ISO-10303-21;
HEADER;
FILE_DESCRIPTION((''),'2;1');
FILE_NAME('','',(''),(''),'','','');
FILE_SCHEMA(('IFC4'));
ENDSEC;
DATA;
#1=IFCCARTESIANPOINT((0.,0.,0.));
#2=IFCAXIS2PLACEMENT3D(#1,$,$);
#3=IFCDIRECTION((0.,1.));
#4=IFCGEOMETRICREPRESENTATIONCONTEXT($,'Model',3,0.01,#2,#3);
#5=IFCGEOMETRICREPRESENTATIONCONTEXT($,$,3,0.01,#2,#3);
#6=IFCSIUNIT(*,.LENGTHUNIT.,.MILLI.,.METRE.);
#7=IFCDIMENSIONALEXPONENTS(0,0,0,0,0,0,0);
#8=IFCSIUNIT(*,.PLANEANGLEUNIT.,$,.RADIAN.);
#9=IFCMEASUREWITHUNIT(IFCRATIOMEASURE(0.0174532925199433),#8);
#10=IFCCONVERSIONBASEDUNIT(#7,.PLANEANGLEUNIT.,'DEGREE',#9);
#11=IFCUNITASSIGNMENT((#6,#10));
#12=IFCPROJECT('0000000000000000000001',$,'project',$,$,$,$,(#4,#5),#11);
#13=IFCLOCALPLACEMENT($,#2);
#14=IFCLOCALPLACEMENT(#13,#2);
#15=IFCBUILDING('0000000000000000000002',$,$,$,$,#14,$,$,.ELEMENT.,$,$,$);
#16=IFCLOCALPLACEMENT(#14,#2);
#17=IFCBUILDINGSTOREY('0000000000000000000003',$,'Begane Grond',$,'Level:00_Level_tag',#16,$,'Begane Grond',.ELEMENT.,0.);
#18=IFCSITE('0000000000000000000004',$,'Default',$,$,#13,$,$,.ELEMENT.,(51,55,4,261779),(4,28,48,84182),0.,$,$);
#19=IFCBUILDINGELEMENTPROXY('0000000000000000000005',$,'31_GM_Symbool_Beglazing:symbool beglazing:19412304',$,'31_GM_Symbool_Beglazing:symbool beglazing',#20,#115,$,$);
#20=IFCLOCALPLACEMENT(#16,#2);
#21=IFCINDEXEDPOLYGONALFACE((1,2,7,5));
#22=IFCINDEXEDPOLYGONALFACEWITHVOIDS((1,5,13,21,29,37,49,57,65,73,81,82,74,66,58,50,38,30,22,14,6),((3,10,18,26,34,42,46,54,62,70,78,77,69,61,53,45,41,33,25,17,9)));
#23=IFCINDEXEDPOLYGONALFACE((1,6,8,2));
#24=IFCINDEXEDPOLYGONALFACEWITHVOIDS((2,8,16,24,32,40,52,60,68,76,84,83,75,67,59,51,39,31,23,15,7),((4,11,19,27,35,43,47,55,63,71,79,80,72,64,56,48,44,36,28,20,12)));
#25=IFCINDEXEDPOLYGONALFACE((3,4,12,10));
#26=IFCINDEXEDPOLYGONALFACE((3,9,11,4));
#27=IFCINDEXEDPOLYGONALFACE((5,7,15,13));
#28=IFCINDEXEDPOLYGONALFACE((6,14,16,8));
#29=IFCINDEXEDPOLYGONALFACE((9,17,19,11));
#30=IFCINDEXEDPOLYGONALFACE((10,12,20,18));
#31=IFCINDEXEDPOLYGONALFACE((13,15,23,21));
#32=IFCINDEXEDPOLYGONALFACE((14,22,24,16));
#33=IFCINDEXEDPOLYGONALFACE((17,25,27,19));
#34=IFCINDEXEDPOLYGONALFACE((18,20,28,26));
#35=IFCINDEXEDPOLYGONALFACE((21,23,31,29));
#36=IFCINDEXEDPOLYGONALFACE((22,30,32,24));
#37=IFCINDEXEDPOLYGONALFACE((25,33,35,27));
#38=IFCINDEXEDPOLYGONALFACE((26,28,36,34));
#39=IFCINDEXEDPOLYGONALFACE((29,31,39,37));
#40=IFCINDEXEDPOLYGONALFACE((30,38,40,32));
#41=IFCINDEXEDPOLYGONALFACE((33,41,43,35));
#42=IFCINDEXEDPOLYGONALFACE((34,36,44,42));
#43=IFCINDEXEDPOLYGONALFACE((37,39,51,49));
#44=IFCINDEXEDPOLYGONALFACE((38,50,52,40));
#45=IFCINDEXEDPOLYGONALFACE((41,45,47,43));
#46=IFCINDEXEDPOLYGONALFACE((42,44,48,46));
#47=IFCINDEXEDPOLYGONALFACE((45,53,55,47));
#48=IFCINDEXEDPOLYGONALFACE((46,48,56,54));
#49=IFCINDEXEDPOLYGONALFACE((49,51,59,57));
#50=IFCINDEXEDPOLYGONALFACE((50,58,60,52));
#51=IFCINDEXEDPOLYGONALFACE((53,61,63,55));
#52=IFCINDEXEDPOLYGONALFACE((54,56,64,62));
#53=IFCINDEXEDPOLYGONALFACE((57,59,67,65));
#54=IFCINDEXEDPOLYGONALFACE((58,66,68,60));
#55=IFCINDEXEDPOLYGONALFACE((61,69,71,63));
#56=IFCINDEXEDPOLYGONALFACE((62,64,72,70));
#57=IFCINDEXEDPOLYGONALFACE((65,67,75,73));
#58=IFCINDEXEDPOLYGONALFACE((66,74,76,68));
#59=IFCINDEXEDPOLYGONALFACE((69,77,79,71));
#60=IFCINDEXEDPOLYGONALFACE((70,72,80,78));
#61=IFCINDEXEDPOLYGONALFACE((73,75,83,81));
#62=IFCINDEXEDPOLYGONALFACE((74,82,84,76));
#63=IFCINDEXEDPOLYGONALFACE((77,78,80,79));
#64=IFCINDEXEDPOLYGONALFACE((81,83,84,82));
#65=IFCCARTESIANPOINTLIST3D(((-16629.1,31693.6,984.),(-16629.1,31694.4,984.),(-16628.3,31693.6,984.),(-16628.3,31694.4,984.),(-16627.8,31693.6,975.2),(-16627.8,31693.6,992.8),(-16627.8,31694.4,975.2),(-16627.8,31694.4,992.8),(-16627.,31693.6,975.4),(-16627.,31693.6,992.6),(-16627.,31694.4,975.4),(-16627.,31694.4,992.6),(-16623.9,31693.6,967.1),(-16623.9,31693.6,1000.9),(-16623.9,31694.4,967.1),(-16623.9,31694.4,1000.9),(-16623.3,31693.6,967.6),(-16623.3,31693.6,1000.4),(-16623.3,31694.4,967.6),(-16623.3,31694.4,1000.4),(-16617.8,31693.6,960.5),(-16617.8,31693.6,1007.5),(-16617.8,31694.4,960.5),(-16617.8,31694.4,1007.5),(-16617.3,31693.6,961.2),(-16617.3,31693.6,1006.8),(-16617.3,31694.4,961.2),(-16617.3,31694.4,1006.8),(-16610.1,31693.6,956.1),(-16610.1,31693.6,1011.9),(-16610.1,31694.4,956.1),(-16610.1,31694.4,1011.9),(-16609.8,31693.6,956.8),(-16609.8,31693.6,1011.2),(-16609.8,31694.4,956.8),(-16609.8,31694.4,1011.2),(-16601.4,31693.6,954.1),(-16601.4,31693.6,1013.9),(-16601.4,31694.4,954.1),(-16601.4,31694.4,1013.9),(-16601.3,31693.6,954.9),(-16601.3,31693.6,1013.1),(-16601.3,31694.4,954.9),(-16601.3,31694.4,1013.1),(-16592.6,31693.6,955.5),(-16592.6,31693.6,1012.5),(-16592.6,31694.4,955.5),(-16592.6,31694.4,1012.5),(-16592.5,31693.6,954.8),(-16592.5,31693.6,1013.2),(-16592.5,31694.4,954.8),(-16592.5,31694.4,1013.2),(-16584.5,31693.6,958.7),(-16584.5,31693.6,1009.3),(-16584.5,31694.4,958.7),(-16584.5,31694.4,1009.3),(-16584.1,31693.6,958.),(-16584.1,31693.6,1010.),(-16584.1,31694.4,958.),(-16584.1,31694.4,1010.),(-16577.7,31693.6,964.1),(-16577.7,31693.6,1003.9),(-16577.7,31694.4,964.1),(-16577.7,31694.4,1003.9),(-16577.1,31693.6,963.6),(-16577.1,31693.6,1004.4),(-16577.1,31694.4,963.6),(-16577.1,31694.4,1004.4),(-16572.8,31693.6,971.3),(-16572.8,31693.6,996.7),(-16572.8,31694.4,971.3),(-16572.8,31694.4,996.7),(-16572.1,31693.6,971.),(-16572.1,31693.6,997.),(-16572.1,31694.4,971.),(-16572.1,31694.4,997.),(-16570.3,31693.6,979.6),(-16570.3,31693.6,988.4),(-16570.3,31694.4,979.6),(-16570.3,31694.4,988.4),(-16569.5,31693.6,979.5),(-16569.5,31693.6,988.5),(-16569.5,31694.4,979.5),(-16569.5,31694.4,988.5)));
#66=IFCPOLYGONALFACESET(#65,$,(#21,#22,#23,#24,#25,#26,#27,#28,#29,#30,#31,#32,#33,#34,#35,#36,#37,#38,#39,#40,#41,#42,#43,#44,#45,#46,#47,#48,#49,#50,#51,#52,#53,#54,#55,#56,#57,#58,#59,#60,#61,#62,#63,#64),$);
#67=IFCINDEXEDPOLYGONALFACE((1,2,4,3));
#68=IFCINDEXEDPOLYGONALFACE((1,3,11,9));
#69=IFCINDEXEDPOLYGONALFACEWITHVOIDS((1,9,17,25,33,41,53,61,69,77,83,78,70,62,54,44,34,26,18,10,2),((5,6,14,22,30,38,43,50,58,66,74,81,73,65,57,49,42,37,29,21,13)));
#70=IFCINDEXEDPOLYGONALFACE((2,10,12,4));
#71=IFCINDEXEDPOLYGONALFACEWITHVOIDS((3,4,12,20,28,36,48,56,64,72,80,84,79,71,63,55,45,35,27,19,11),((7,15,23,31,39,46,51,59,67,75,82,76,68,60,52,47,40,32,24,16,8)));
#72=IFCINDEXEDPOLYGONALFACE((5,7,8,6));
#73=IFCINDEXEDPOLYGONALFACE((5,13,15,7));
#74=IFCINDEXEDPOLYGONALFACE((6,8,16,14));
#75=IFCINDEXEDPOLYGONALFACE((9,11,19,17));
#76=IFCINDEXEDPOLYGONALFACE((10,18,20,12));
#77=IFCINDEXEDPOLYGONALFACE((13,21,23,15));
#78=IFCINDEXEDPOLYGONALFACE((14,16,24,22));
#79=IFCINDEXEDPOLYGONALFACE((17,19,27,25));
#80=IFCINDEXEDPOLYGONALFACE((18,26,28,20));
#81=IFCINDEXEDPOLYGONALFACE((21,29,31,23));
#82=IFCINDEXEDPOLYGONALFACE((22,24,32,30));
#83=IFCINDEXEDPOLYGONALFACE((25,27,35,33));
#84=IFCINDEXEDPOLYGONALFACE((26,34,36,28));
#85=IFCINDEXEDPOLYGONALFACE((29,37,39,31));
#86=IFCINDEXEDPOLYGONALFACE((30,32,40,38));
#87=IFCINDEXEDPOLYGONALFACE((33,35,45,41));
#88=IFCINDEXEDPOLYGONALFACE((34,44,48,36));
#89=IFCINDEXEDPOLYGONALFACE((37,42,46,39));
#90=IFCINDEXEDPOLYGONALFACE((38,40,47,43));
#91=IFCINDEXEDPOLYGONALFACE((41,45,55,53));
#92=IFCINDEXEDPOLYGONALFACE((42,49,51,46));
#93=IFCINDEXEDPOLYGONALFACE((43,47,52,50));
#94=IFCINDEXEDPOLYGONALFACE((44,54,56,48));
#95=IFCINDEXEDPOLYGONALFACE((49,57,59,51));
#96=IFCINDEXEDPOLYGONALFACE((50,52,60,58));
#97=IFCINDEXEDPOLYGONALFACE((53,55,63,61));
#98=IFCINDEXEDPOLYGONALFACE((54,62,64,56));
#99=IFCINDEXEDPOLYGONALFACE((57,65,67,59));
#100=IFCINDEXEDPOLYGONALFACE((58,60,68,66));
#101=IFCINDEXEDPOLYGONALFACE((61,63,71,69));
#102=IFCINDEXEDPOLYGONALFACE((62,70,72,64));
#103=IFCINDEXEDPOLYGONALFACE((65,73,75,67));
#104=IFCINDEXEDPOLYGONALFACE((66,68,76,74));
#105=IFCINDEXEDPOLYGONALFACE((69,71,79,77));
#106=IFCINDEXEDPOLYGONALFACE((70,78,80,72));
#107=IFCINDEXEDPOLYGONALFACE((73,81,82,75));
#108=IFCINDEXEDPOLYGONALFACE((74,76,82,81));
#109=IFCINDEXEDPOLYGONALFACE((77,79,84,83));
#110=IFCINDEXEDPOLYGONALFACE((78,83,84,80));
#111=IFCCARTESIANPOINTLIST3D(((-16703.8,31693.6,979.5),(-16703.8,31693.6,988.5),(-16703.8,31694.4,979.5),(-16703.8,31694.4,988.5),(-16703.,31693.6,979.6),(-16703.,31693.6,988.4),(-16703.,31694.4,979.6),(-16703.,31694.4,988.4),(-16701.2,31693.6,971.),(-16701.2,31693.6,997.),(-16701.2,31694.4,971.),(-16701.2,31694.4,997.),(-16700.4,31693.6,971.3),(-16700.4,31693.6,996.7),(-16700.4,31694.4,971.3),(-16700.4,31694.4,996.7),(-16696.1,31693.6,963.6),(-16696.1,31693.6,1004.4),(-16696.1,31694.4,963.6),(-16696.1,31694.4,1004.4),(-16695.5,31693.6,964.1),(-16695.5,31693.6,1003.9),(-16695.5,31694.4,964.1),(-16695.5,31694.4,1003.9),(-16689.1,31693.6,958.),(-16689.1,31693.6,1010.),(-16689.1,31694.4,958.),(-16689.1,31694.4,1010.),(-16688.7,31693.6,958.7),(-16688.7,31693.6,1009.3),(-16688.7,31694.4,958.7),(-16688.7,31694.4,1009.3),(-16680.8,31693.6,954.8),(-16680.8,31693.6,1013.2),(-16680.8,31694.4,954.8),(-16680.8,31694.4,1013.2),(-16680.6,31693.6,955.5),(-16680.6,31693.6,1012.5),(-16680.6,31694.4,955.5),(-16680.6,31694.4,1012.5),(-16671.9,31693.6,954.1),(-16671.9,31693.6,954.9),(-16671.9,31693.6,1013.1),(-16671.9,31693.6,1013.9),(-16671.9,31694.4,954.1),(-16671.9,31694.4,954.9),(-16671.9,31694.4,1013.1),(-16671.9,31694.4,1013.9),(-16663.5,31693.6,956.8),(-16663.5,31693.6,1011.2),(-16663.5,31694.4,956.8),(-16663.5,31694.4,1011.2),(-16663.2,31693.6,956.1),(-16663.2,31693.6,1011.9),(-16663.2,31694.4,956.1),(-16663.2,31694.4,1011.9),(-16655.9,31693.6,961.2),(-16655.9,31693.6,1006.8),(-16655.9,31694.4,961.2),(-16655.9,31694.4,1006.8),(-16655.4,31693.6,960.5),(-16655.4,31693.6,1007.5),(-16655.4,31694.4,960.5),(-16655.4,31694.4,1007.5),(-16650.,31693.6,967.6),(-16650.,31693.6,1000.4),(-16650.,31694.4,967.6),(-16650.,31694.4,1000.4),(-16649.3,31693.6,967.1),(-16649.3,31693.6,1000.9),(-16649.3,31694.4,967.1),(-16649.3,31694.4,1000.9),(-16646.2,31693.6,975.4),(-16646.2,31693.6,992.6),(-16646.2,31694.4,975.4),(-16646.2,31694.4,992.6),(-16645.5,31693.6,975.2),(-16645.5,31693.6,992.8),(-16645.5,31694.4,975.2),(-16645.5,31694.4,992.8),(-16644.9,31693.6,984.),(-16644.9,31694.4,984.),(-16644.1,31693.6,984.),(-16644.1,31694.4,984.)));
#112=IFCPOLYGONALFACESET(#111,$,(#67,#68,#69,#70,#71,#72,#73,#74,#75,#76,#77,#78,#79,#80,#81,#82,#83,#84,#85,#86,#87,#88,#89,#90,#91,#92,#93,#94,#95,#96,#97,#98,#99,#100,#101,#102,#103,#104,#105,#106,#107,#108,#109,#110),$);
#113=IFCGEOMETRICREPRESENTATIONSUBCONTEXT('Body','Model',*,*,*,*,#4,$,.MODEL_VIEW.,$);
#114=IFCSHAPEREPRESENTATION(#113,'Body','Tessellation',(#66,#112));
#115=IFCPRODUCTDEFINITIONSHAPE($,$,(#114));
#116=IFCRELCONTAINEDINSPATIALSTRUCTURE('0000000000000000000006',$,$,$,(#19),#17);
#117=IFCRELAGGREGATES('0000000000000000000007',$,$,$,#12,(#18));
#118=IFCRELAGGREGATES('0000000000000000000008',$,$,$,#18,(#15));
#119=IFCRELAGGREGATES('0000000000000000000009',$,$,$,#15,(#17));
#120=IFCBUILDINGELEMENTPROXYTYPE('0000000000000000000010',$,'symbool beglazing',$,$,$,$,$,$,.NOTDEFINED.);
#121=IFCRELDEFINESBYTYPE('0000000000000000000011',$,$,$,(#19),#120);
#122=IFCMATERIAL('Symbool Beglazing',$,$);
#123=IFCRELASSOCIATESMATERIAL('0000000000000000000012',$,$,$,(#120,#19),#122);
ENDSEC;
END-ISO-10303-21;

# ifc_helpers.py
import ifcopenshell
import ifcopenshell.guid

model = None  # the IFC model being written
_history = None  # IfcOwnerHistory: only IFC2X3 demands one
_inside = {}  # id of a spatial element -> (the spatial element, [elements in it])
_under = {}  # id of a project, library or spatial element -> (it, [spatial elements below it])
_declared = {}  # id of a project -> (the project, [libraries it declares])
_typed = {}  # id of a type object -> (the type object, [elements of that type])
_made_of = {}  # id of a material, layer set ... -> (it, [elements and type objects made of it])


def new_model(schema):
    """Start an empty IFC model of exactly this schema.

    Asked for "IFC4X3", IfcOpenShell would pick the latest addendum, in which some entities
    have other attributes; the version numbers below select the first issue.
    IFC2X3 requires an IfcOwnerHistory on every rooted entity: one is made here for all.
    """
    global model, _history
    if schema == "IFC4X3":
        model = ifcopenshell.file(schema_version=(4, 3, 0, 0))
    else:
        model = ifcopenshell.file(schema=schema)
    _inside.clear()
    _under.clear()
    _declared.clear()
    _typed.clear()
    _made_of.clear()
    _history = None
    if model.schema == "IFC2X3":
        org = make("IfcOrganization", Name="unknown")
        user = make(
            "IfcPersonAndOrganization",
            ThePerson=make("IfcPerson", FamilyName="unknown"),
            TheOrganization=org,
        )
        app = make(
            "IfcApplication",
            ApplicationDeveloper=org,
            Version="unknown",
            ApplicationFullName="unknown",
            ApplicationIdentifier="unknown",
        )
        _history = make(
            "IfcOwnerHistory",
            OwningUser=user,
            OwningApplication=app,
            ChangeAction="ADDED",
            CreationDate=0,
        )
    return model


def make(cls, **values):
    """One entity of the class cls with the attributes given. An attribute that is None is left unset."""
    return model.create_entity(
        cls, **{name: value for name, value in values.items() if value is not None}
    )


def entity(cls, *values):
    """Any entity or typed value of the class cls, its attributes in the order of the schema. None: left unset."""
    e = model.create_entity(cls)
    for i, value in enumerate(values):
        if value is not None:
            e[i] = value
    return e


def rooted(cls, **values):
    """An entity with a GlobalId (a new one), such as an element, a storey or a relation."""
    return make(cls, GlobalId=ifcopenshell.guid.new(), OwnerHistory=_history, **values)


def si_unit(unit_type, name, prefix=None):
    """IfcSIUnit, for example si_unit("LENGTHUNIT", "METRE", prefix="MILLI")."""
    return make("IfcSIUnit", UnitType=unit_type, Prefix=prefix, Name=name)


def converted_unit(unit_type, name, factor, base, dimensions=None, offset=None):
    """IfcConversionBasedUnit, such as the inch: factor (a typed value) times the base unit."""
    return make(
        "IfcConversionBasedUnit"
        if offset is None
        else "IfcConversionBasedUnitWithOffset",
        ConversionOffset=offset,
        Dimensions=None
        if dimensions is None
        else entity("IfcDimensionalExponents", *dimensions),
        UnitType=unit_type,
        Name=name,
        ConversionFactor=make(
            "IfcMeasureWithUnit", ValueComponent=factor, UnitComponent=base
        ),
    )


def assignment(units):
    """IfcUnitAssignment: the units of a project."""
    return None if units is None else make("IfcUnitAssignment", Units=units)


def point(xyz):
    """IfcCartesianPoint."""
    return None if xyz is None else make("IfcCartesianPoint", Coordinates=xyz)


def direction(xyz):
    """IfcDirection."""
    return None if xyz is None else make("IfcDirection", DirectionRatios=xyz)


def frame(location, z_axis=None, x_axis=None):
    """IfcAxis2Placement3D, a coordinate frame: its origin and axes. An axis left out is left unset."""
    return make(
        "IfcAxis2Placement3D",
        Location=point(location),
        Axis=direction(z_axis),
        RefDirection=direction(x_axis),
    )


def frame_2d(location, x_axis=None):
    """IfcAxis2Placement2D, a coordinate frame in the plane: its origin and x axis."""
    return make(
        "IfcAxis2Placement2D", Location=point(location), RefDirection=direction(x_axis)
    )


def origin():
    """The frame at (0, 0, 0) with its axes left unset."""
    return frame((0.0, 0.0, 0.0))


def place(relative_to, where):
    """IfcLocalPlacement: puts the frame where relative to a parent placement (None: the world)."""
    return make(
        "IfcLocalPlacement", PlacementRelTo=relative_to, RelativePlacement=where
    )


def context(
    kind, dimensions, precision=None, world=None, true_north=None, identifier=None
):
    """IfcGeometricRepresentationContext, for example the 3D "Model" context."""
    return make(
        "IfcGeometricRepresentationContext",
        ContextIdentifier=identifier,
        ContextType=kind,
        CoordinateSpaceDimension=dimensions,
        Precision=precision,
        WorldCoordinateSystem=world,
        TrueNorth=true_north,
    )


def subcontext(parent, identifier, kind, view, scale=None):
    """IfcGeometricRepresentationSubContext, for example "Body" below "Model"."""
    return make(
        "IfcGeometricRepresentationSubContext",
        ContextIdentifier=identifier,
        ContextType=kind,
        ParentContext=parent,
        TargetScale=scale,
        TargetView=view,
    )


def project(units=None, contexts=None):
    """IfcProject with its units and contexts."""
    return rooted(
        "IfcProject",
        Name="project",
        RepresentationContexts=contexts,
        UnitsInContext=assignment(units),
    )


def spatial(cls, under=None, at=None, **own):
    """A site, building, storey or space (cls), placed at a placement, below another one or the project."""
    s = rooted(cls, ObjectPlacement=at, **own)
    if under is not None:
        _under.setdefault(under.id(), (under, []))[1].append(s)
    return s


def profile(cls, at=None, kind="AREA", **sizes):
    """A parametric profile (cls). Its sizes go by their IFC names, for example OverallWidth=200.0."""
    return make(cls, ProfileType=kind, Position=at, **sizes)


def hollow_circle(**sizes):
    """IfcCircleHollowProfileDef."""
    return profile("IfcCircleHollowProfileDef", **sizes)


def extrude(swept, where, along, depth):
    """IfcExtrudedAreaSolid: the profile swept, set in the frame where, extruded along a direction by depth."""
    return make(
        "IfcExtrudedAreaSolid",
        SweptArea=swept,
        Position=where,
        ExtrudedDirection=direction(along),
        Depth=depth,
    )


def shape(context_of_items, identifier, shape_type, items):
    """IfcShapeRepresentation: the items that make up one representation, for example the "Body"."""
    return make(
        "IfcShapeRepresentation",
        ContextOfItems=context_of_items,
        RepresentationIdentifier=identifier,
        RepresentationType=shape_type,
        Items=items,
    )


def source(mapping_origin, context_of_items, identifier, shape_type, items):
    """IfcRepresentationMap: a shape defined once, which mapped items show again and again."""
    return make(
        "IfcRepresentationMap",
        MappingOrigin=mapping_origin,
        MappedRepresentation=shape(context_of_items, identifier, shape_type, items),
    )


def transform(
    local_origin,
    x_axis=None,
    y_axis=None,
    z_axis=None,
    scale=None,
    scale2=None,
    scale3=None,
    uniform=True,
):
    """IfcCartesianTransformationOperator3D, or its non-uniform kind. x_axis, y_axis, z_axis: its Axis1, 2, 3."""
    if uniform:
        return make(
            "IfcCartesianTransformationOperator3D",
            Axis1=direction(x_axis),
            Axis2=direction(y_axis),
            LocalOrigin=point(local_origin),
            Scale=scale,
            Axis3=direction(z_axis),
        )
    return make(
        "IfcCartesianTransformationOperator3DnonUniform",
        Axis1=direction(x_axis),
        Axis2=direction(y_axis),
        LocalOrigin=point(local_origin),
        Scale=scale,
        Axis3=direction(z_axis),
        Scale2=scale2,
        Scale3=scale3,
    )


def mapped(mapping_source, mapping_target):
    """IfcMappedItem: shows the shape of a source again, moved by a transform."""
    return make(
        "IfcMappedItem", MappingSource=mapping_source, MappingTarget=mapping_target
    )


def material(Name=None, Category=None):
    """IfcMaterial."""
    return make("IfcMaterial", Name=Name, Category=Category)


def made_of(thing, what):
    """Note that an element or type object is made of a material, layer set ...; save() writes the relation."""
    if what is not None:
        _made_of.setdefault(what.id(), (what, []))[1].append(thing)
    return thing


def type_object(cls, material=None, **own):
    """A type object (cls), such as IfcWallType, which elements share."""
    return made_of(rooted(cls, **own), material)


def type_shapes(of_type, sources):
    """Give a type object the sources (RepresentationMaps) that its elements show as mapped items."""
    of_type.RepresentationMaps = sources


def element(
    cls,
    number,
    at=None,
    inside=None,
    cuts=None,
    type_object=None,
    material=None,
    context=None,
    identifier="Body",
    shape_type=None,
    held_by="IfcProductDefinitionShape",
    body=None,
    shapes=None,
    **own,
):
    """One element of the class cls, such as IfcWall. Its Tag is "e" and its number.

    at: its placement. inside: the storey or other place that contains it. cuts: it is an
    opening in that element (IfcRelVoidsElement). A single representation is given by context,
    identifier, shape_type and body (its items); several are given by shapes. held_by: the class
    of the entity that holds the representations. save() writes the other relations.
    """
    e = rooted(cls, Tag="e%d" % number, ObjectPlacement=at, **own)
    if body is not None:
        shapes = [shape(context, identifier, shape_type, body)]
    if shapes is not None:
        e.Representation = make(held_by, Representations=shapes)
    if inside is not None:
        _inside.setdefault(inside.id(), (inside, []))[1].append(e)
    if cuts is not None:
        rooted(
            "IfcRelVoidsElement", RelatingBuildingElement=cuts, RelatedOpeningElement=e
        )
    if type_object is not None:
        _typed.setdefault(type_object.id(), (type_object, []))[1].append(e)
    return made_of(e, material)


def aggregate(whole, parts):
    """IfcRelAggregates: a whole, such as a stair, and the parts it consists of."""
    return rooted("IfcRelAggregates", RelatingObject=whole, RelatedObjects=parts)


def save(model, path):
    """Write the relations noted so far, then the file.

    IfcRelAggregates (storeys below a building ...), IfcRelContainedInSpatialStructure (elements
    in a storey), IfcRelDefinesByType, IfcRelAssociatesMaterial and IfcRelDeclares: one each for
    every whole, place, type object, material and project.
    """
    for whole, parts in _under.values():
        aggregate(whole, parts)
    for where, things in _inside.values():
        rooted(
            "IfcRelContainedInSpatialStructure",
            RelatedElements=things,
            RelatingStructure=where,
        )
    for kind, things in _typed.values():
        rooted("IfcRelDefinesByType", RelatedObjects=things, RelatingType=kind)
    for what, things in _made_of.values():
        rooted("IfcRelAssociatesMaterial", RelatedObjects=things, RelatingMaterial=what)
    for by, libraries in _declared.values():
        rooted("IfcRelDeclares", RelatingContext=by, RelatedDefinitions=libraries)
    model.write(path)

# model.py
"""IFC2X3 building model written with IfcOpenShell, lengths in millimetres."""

from ifc_helpers import new_model, entity, si_unit, converted_unit, direction, frame, frame_2d, origin, place, context, subcontext, project, spatial, hollow_circle, extrude, source, transform, mapped, material, type_object, type_shapes, element, save


model = new_model("IFC2X3")

# Units and contexts
model_context = context("Model", 3, precision=0.01, world=origin(), true_north=direction((0.0, 1.0)))
context_of_model = context(None, 3, precision=0.01, world=origin(), true_north=direction((0.0, 1.0)))
body_context = subcontext(model_context, "Body", "Model", "MODEL_VIEW")
ifc_project = project(units=[si_unit("LENGTHUNIT", "METRE", prefix="MILLI"), converted_unit("PLANEANGLEUNIT", "DEGREE", entity("IfcRatioMeasure", 0.0174532925199433), si_unit("PLANEANGLEUNIT", "RADIAN"), dimensions=[0, 0, 0, 0, 0, 0, 0])], contexts=[model_context, context_of_model])

# Site, building, storey
site_placement = place(None, origin())
site = spatial("IfcSite", under=ifc_project, at=site_placement, Name="Default", CompositionType="ELEMENT", RefLatitude=(51, 55, 4, 261779), RefLongitude=(4, 28, 48, 84182), RefElevation=0.0)
building_placement = place(site_placement, origin())
building = spatial("IfcBuilding", under=site, at=building_placement, CompositionType="ELEMENT")
storey_placement = place(building_placement, origin())
storey = spatial("IfcBuildingStorey", under=building, at=storey_placement, Name="Begane Grond", ObjectType="Level:00_Level_tag", LongName="Begane Grond", CompositionType="ELEMENT", Elevation=0.0)

# Building element proxy
ifc_material_1 = material(Name="Symbool Beglazing")
building_element_proxy_type_1 = type_object("IfcBuildingElementProxyType", Name="symbool beglazing", PredefinedType="NOTDEFINED", material=ifc_material_1)
shared_shape_1 = source(origin(), body_context, "Body", "SweptSolid", [
    extrude(hollow_circle(Radius=30.0, WallThickness=0.8, at=frame_2d((0.0, 0.0), x_axis=(1.0, 0.0))), frame((37.5, 0.0, 0.0), z_axis=(0.0, 0.0, 1.0), x_axis=(-1.0, 0.0, 0.0)), (0.0, 0.0, 1.0), 0.8),
    extrude(hollow_circle(Radius=30.0, WallThickness=0.8, at=frame_2d((0.0, 0.0), x_axis=(1.0, 0.0))), frame((-37.5, 0.0, 0.0)), (0.0, 0.0, 1.0), 0.8),
])
type_shapes(building_element_proxy_type_1, [shared_shape_1])
for number, where, z_axis, x_axis, name in (
    (1, (-16636.6, 31694.4, 984.0), (0.0, -1.0, 0.0), (1.0, 0.0, 0.0), "31_GM_Symbool_Beglazing:symbool beglazing:19412304"),
):
    element("IfcBuildingElementProxy", number, at=place(storey_placement, frame(where, z_axis=z_axis, x_axis=x_axis)), inside=storey, type_object=building_element_proxy_type_1, material=ifc_material_1, Name=name, ObjectType="31_GM_Symbool_Beglazing:symbool beglazing", context=body_context, shape_type="MappedRepresentation", body=[
        mapped(shared_shape_1, transform((0.0, 0.0, 0.0), scale=1.0)),
    ])

save(model, "model.ifc")
